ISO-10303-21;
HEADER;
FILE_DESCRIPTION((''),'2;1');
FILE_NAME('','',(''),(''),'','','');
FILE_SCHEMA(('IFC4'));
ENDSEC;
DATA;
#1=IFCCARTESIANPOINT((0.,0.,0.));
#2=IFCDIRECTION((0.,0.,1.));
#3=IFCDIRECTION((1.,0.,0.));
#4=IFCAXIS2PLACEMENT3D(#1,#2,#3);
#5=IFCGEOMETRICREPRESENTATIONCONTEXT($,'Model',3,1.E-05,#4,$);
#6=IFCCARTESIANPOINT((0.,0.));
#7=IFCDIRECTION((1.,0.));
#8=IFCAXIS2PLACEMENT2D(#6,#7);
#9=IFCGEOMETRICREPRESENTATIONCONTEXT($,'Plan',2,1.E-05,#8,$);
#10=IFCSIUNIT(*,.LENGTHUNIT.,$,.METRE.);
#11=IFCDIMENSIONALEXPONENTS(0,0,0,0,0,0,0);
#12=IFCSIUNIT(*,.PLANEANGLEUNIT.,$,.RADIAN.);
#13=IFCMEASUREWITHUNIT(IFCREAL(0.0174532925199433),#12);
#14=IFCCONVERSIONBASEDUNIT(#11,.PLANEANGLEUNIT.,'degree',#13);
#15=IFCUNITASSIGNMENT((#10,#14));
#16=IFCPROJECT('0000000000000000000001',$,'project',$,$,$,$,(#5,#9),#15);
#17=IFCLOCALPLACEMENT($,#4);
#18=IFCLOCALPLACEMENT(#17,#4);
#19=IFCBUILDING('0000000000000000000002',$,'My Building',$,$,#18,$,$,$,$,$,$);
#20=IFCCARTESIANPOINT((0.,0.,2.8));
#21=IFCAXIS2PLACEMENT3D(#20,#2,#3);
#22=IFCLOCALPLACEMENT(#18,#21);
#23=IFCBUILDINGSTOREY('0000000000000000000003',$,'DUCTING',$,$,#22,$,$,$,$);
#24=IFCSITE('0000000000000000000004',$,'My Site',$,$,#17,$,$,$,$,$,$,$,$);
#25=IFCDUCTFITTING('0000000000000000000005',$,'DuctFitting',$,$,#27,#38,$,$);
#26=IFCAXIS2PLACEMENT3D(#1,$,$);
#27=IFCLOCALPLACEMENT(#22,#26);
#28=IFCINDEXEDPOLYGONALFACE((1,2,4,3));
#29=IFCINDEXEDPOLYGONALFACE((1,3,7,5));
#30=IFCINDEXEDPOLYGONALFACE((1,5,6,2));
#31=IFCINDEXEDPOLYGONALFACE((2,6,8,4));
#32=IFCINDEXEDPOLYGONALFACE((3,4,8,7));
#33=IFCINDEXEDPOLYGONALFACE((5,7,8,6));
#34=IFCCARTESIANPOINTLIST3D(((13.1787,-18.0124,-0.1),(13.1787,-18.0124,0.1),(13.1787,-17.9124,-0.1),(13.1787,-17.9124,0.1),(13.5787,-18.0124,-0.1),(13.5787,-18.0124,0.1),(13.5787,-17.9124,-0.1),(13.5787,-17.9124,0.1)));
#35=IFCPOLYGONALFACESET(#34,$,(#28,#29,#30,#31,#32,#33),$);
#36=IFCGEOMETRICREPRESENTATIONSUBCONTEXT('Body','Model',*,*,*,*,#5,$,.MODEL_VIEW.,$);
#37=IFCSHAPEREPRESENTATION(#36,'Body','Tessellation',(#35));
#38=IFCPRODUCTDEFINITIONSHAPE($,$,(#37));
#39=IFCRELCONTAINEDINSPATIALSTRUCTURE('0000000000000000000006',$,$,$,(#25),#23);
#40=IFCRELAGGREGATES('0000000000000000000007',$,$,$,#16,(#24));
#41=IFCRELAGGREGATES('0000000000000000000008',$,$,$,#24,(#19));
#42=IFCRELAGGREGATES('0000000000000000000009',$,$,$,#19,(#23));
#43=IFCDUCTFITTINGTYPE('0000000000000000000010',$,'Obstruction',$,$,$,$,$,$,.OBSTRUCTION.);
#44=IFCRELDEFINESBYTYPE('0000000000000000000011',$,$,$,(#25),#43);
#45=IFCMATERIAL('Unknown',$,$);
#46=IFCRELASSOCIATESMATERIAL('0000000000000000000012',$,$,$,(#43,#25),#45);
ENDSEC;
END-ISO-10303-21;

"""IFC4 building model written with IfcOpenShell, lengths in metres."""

from ifc_helpers import new_model, entity, si_unit, converted_unit, frame, origin_with_axes, origin_2d_with_axis, place, context, subcontext, project, spatial, rectangle, extrude, material, material_profile, profile_set, profile_usage, type_object, element, save


model = new_model("IFC4")

# Units and contexts
model_context = context("Model", 3, precision=1e-05, world=origin_with_axes())
plan_context = context("Plan", 2, precision=1e-05, world=origin_2d_with_axis())
body_context = subcontext(model_context, "Body", "Model", "MODEL_VIEW")
ifc_project = project(units=[si_unit("LENGTHUNIT", "METRE"), converted_unit("PLANEANGLEUNIT", "degree", entity("IfcReal", 0.0174532925199433), si_unit("PLANEANGLEUNIT", "RADIAN"), dimensions=[0, 0, 0, 0, 0, 0, 0])], contexts=[model_context, plan_context])

# Site, building, storey
site_placement = place(None, origin_with_axes())
site = spatial("IfcSite", under=ifc_project, at=site_placement, Name="My Site")
building_placement = place(site_placement, origin_with_axes())
building = spatial("IfcBuilding", under=site, at=building_placement, Name="My Building")
storey_placement = place(building_placement, frame((0.0, 0.0, 2.8), z_axis=(0.0, 0.0, 1.0), x_axis=(1.0, 0.0, 0.0)))
storey = spatial("IfcBuildingStorey", under=building, at=storey_placement, Name="DUCTING")

# Shared definitions
ifc_material = material(Name="Unknown")

# Duct fitting
ifc_material_profile_1 = material_profile(ifc_material, rectangle(XDim=0.4, YDim=0.2))
ifc_profile_set_1 = profile_set([ifc_material_profile_1])
duct_fitting_type_1 = type_object("IfcDuctFittingType", Name="Obstruction", PredefinedType="OBSTRUCTION", material=ifc_profile_set_1)
ifc_profile_usage_1 = profile_usage(ifc_profile_set_1, cardinal=5)
duct_fitting_1_placement = place(storey_placement, frame((13.3787, -17.9124, 0.0), z_axis=(0.0, -1.0, 0.0), x_axis=(1.0, 0.0, 0.0)))
element("IfcDuctFitting", 1, at=duct_fitting_1_placement, inside=storey, type_object=duct_fitting_type_1, material=ifc_profile_usage_1, Name="DuctFitting", context=body_context, shape_type="SweptSolid", body=[
    extrude(rectangle(XDim=0.4, YDim=0.2), origin_with_axes(), (0.0, 0.0, 1.0), 0.1),
])

save(model, "model.ifc")
